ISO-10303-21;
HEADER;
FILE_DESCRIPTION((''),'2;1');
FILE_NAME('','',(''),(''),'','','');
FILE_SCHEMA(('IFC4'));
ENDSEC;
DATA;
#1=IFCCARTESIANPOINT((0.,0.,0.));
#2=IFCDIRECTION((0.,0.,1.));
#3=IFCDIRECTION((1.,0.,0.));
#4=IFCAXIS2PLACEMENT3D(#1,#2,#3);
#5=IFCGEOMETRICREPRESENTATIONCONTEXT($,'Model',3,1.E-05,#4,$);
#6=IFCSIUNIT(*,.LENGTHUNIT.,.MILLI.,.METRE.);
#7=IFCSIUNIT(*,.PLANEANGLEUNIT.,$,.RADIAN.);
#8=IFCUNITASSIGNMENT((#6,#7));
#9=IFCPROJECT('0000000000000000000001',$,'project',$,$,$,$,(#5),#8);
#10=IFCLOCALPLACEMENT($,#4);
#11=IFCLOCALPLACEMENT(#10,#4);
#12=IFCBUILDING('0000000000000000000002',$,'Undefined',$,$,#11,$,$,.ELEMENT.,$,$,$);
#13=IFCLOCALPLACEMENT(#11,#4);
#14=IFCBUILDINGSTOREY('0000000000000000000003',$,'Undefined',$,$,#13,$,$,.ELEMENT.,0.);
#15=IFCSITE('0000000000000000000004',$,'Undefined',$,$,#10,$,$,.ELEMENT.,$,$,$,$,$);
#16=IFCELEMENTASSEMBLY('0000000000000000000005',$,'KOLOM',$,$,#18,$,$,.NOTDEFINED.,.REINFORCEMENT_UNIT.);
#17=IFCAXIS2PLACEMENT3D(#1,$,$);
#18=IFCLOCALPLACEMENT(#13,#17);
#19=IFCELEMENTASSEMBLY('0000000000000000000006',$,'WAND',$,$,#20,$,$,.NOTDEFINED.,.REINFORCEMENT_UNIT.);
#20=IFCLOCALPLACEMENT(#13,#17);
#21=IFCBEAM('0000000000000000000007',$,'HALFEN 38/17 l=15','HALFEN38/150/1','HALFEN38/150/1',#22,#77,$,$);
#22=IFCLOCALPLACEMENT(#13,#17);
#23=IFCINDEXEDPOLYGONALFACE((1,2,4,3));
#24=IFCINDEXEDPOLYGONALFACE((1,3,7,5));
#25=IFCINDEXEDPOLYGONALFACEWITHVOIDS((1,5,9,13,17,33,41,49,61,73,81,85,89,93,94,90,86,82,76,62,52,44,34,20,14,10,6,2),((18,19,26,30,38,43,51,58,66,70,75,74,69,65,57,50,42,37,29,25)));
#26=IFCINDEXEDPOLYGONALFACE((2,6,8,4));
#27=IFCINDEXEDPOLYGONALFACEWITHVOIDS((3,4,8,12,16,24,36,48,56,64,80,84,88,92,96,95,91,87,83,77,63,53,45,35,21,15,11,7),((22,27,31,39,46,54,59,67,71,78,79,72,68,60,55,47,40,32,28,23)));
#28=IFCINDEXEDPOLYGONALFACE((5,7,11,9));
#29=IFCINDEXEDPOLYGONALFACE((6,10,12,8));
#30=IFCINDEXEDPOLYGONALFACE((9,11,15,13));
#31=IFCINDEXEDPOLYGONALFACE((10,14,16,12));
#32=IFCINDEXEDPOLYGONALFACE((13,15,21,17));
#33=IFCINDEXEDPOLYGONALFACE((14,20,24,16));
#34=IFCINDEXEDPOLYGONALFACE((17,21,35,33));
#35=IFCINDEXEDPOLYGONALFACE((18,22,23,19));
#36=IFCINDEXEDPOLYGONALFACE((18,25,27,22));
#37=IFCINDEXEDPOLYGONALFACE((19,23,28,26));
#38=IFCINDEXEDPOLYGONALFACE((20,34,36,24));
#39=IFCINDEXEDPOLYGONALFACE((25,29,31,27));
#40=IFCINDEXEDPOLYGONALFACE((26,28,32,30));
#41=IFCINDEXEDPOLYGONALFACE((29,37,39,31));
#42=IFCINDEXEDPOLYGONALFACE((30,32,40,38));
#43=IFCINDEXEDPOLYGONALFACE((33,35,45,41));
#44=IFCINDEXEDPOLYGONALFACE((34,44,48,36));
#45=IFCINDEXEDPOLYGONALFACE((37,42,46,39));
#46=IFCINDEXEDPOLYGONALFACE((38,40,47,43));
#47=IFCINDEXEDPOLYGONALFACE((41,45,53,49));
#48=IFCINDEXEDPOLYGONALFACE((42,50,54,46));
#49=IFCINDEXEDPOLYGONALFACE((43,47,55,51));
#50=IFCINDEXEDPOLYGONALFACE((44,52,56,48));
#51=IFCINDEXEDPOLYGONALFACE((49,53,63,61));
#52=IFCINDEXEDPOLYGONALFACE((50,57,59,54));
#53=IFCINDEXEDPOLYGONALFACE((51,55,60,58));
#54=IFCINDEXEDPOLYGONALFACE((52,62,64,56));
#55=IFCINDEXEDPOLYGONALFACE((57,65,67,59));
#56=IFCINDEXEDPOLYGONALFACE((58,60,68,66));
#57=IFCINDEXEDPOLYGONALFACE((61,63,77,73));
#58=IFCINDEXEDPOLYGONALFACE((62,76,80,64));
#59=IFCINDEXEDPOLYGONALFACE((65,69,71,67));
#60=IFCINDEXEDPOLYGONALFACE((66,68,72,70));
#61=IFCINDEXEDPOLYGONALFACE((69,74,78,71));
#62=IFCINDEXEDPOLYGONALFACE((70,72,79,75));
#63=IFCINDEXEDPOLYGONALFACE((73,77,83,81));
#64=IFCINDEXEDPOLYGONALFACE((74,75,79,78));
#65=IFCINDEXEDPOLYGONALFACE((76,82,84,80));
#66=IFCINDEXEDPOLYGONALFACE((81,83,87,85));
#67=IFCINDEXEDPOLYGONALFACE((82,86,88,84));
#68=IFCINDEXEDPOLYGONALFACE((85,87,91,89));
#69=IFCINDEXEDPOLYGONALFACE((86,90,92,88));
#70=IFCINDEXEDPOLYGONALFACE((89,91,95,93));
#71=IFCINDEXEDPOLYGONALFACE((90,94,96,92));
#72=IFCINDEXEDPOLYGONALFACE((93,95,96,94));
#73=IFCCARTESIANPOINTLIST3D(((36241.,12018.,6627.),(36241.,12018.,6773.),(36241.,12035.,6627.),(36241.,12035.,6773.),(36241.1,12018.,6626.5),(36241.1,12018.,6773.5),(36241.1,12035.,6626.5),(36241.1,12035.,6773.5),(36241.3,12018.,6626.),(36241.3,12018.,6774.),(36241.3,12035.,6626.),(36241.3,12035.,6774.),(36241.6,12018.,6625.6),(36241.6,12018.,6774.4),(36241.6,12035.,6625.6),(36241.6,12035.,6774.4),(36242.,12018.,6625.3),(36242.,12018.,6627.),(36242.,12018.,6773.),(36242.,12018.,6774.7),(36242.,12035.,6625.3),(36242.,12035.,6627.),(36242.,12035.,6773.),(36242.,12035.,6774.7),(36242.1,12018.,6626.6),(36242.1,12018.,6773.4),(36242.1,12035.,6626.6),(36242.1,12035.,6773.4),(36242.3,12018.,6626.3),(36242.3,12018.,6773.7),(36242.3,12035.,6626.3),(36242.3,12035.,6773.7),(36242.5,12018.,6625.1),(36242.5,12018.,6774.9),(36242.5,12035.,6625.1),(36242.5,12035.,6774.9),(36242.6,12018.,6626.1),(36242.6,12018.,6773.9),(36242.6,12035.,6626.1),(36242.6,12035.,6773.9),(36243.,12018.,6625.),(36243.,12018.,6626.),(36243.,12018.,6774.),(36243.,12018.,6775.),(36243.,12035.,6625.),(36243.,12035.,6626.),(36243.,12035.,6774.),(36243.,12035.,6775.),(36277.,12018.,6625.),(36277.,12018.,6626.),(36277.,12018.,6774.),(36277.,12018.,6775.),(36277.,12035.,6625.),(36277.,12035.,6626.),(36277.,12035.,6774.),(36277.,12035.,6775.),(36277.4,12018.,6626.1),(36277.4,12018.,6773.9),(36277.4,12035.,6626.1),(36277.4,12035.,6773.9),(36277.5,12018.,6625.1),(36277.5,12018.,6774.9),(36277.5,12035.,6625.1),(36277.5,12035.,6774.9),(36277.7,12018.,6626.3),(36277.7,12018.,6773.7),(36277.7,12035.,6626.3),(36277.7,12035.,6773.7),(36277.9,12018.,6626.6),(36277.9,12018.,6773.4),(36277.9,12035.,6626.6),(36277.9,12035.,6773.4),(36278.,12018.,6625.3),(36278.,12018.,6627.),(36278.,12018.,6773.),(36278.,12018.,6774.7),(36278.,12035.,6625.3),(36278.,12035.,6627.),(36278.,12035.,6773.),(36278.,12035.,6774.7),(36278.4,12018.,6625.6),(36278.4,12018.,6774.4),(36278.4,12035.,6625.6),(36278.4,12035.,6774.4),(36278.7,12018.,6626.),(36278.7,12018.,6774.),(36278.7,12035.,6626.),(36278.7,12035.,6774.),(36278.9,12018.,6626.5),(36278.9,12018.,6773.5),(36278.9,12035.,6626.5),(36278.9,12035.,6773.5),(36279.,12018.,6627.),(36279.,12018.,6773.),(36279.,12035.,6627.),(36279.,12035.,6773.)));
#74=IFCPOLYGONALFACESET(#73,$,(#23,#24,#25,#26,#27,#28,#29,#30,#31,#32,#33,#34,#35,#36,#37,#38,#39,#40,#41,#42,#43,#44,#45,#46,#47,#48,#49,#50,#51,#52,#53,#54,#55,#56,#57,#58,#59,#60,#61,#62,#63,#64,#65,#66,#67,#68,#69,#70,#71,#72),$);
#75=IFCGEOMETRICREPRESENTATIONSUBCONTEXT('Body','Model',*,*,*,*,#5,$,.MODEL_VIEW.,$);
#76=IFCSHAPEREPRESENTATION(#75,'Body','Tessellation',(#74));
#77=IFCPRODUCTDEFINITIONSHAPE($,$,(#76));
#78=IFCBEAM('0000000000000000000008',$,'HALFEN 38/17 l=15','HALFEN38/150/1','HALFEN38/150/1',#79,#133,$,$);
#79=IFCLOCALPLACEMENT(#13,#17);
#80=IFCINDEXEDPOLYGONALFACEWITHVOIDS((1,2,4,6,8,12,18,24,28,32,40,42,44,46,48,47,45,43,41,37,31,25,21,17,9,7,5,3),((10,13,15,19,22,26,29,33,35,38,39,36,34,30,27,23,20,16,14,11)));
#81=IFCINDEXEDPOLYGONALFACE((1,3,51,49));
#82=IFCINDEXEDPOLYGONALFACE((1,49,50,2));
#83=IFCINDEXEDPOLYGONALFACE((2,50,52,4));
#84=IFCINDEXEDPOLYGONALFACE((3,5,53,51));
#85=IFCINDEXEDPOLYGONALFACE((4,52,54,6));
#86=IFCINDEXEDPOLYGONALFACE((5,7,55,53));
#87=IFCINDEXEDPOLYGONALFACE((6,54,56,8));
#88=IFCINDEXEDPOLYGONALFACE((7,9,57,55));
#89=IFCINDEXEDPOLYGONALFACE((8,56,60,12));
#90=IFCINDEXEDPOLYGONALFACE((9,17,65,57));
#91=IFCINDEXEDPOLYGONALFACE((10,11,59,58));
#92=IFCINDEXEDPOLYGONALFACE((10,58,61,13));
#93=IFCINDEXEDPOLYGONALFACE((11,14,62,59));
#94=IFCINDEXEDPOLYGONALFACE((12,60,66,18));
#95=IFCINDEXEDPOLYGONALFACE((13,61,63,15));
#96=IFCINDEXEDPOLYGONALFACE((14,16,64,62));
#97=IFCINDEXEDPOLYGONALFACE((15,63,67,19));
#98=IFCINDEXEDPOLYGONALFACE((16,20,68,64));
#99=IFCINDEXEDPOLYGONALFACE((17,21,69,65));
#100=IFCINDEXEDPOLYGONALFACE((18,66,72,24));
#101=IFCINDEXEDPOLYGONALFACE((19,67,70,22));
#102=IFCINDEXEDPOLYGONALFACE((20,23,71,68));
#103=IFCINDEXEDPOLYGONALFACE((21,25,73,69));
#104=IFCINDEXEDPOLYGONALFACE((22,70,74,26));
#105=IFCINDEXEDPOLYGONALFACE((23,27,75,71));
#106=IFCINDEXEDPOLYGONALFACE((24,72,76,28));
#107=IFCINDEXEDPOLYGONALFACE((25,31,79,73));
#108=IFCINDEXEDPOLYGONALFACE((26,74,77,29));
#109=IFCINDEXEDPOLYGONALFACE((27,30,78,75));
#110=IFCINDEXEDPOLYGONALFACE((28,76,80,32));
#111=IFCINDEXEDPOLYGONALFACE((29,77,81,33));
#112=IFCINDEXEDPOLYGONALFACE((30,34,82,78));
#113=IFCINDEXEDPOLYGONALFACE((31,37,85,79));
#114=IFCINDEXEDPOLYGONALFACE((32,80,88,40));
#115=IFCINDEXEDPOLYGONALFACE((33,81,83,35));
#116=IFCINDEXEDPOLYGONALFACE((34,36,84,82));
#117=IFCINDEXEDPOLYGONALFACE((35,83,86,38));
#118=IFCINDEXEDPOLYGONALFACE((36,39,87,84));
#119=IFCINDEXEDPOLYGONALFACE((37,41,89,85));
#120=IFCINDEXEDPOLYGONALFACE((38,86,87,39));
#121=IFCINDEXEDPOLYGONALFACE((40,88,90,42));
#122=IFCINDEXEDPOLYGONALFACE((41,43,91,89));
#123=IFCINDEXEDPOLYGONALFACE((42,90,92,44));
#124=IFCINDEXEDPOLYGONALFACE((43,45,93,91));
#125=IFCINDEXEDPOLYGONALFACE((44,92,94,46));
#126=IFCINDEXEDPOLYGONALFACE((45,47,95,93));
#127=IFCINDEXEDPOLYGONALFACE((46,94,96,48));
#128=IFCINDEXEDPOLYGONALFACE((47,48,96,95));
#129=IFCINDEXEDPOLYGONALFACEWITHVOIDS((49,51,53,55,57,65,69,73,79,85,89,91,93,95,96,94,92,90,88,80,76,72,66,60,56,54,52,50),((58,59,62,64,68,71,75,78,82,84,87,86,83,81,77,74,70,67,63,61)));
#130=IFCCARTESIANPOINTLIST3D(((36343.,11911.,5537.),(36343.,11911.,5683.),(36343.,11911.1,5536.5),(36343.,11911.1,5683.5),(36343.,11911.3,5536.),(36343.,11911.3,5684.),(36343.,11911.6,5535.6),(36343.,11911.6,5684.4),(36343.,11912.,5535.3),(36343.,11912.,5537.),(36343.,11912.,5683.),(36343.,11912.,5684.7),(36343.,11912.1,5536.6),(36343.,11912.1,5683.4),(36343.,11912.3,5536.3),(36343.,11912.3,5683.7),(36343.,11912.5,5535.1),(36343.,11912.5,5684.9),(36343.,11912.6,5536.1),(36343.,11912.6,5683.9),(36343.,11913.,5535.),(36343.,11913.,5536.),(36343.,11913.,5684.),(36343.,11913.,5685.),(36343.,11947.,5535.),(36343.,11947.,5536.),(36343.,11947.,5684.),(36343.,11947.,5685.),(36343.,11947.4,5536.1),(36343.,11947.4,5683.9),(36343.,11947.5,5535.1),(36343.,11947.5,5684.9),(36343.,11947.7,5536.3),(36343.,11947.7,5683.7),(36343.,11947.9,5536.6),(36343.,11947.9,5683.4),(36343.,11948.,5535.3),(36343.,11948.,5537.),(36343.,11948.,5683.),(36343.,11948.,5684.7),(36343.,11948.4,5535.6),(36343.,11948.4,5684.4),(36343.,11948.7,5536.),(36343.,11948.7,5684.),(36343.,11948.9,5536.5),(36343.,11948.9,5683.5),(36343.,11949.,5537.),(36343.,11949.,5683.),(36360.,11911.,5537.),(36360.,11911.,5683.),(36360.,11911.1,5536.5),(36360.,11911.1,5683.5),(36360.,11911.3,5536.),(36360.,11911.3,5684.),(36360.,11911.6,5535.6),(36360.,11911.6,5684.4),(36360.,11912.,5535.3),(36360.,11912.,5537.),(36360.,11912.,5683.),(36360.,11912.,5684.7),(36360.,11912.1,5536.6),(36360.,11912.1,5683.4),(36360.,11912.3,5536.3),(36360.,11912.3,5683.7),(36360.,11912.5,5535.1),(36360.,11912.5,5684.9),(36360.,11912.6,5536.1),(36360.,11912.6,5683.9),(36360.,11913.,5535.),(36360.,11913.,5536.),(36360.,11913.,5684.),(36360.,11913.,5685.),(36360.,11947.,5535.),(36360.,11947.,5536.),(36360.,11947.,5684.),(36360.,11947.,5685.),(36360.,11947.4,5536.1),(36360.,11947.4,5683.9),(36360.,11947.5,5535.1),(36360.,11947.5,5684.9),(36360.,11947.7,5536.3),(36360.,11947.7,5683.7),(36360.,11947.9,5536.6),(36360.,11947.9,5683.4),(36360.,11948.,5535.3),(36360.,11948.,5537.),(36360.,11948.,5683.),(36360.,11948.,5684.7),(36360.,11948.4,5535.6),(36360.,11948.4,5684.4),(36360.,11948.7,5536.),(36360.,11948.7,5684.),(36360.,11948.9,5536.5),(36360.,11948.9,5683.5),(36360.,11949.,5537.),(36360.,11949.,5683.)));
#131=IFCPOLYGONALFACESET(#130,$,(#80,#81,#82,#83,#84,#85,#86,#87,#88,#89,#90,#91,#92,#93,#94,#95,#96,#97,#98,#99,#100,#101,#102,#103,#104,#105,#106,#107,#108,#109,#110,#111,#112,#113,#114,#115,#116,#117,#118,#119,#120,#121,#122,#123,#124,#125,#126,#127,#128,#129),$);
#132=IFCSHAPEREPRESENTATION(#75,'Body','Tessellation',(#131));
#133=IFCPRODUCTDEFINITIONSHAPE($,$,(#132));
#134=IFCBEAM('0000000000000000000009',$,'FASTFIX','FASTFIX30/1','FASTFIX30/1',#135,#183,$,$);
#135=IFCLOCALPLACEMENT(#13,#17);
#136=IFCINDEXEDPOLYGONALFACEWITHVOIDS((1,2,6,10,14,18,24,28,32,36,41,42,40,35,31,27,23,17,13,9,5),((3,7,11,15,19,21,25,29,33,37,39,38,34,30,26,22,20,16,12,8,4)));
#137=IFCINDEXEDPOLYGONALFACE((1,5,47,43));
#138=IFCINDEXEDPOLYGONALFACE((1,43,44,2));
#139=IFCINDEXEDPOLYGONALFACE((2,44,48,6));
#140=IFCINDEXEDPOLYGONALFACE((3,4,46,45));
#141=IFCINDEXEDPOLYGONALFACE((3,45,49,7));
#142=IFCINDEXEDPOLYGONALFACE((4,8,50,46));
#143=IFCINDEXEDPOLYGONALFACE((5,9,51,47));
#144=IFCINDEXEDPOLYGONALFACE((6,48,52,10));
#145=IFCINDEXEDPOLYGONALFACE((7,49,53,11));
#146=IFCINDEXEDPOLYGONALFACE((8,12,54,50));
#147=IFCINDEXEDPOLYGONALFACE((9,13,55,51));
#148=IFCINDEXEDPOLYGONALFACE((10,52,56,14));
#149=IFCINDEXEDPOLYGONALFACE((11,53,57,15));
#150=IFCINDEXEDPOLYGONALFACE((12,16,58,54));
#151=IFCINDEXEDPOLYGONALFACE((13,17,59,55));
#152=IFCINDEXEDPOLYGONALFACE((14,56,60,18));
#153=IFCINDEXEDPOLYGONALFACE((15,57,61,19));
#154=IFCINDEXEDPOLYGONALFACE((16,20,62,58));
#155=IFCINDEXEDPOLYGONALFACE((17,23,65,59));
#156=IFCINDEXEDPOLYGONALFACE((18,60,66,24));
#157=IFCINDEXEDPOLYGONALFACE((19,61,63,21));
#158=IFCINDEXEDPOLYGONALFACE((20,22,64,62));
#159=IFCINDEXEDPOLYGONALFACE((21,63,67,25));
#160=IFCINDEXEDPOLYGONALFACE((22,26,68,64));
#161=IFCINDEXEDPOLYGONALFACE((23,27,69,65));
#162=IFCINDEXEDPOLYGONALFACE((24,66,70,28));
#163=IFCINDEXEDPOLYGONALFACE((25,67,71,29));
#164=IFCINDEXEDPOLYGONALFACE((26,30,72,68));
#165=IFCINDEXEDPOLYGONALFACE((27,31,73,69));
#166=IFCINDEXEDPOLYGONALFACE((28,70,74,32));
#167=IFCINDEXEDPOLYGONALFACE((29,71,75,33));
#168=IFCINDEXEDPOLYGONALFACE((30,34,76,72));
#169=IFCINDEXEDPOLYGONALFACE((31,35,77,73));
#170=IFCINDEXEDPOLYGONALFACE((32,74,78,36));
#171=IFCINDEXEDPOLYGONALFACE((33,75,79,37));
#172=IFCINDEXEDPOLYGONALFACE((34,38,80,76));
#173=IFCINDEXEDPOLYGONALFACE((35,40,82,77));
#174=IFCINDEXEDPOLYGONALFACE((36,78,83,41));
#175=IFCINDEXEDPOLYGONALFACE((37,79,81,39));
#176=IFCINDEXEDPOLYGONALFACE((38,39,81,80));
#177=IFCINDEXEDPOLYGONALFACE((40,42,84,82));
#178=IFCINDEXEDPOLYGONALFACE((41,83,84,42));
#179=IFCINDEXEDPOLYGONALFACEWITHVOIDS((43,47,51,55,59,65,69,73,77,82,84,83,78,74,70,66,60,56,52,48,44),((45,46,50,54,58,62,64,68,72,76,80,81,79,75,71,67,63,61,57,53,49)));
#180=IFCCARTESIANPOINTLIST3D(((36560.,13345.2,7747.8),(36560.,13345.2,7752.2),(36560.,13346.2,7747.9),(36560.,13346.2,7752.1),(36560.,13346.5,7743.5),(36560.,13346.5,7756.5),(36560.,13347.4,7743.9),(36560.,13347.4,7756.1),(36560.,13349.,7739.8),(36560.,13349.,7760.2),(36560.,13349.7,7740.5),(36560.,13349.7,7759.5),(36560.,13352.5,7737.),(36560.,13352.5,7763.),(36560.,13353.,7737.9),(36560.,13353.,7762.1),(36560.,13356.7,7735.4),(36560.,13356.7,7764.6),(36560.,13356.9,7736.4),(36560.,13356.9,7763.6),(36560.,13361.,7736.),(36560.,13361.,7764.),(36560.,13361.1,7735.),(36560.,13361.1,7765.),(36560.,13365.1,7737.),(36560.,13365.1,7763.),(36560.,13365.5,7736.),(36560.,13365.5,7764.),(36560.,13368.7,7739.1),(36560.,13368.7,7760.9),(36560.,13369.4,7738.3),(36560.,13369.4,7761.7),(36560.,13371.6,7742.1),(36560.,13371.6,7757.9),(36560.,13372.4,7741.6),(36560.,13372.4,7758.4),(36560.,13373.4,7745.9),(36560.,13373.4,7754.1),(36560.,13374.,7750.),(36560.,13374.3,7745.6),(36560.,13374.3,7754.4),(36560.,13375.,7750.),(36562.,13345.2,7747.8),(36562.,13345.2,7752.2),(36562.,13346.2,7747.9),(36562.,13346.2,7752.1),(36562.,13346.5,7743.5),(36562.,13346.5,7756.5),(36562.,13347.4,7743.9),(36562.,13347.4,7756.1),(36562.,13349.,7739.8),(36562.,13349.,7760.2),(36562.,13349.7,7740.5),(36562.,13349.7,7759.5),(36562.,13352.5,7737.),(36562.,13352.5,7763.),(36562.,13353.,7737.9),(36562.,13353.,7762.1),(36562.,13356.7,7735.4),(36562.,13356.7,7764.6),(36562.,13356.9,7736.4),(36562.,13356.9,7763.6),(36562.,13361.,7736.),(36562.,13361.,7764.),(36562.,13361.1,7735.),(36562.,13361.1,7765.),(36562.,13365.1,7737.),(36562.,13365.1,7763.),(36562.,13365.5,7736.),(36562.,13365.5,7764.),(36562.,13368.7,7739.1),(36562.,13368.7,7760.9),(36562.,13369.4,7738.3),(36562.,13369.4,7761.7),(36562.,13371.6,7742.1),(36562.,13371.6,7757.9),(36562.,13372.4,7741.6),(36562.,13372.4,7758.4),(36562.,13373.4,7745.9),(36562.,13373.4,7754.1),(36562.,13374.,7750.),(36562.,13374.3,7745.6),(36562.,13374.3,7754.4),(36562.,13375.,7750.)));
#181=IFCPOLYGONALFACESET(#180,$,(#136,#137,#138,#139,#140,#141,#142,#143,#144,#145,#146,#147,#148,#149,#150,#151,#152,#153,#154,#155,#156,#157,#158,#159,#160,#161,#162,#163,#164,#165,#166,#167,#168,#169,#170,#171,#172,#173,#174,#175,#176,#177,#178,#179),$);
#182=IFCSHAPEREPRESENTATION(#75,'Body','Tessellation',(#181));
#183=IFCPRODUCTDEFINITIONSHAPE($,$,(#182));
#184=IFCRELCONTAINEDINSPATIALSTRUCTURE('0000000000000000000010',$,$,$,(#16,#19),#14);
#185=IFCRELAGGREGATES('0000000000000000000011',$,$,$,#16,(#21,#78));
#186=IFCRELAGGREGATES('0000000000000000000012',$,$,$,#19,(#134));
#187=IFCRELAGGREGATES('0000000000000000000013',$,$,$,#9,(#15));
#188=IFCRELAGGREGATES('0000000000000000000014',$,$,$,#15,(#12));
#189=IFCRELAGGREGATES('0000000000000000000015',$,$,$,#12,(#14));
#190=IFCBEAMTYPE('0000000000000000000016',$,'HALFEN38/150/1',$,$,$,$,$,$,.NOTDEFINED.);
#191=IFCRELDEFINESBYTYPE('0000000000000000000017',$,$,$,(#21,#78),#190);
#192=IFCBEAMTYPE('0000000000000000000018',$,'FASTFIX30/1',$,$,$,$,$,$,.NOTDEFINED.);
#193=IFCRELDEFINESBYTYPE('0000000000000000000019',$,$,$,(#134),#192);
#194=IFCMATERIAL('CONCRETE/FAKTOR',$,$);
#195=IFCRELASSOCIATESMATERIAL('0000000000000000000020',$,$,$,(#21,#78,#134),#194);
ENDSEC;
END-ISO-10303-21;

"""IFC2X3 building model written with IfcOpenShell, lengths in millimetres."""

from ifc_helpers import new_model, si_unit, frame, frame_2d, origin_with_axes, place, context, subcontext, project, spatial, hollow_rectangle, hollow_circle, extrude, material, type_object, element, aggregate, save


model = new_model("IFC2X3")

# Units and contexts
model_context = context("Model", 3, precision=1e-05, world=origin_with_axes())
body_context = subcontext(model_context, "Body", "Model", "MODEL_VIEW")
ifc_project = project(units=[si_unit("LENGTHUNIT", "METRE", prefix="MILLI"), si_unit("PLANEANGLEUNIT", "RADIAN")], contexts=[model_context])

# Site, building, storey
site_placement = place(None, origin_with_axes())
site = spatial("IfcSite", under=ifc_project, at=site_placement, Name="Undefined", CompositionType="ELEMENT")
building_placement = place(site_placement, origin_with_axes())
building = spatial("IfcBuilding", under=site, at=building_placement, Name="Undefined", CompositionType="ELEMENT")
storey_placement = place(building_placement, origin_with_axes())
storey = spatial("IfcBuildingStorey", under=building, at=storey_placement, Name="Undefined", CompositionType="ELEMENT", Elevation=0.0)

# Element assembly
assembly_1_placement = place(storey_placement, origin_with_axes())
assembly_1 = element("IfcElementAssembly", 1, at=assembly_1_placement, inside=storey, Name="KOLOM", AssemblyPlace="NOTDEFINED", PredefinedType="REINFORCEMENT_UNIT")
ifc_material_1 = material(Name="CONCRETE/FAKTOR")

# Element assembly
assembly_2_placement = place(storey_placement, origin_with_axes())
assembly_2 = element("IfcElementAssembly", 2, at=assembly_2_placement, inside=storey, Name="WAND", AssemblyPlace="NOTDEFINED", PredefinedType="REINFORCEMENT_UNIT")

# Beams
beam_type_1 = type_object("IfcBeamType", Name="HALFEN38/150/1", PredefinedType="NOTDEFINED")
beam_1_placement = place(assembly_1_placement, frame((36260.0, 12035.0, 6700.0), z_axis=(-1.0, 0.0, 0.0), x_axis=(0.0, -1.0, 0.0)))
beam_1 = element("IfcBeam", 3, at=beam_1_placement, type_object=beam_type_1, material=ifc_material_1, Name="HALFEN 38/17 l=15", Description="HALFEN38/150/1", ObjectType="HALFEN38/150/1", context=body_context, shape_type="SweptSolid", body=[
    extrude(hollow_rectangle(XDim=150.0, YDim=38.0, WallThickness=1.0, InnerFilletRadius=1.0, OuterFilletRadius=2.0, at=frame_2d((0.0, 0.0), x_axis=(1.0, 0.0))), frame((17.0, 0.0, 0.0), z_axis=(-1.0, 0.0, 0.0), x_axis=(0.0, -1.0, 0.0)), (0.0, 0.0, 1.0), 17.0),
])
beam_2_placement = place(assembly_1_placement, frame((36360.0, 11930.0, 5610.0), z_axis=(0.0, 1.0, 0.0), x_axis=(-1.0, 0.0, 0.0)))
beam_2 = element("IfcBeam", 4, at=beam_2_placement, type_object=beam_type_1, material=ifc_material_1, Name="HALFEN 38/17 l=15", Description="HALFEN38/150/1", ObjectType="HALFEN38/150/1", context=body_context, shape_type="SweptSolid", body=[
    extrude(hollow_rectangle(XDim=150.0, YDim=38.0, WallThickness=1.0, InnerFilletRadius=1.0, OuterFilletRadius=2.0, at=frame_2d((0.0, 0.0), x_axis=(1.0, 0.0))), frame((17.0, 0.0, 0.0), z_axis=(-1.0, 0.0, 0.0), x_axis=(0.0, -1.0, 0.0)), (0.0, 0.0, 1.0), 17.0),
])
aggregate(assembly_1, [beam_1, beam_2])
beam_type_2 = type_object("IfcBeamType", Name="FASTFIX30/1", PredefinedType="NOTDEFINED")
beam_3_placement = place(assembly_2_placement, frame((36560.0, 13360.0, 7750.0), z_axis=(0.0, 0.0, -1.0), x_axis=(1.0, 0.0, 0.0)))
beam_3 = element("IfcBeam", 5, at=beam_3_placement, type_object=beam_type_2, material=ifc_material_1, Name="FASTFIX", Description="FASTFIX30/1", ObjectType="FASTFIX30/1", context=body_context, shape_type="SweptSolid", body=[
    extrude(hollow_circle(Radius=15.0, WallThickness=1.0, at=frame_2d((0.0, 0.0), x_axis=(1.0, 0.0))), frame((2.0, 0.0, 0.0), z_axis=(-1.0, 0.0, 0.0), x_axis=(0.0, -1.0, 0.0)), (0.0, 0.0, 1.0), 2.0),
])

aggregate(assembly_2, [beam_3])

save(model, "model.ifc")
